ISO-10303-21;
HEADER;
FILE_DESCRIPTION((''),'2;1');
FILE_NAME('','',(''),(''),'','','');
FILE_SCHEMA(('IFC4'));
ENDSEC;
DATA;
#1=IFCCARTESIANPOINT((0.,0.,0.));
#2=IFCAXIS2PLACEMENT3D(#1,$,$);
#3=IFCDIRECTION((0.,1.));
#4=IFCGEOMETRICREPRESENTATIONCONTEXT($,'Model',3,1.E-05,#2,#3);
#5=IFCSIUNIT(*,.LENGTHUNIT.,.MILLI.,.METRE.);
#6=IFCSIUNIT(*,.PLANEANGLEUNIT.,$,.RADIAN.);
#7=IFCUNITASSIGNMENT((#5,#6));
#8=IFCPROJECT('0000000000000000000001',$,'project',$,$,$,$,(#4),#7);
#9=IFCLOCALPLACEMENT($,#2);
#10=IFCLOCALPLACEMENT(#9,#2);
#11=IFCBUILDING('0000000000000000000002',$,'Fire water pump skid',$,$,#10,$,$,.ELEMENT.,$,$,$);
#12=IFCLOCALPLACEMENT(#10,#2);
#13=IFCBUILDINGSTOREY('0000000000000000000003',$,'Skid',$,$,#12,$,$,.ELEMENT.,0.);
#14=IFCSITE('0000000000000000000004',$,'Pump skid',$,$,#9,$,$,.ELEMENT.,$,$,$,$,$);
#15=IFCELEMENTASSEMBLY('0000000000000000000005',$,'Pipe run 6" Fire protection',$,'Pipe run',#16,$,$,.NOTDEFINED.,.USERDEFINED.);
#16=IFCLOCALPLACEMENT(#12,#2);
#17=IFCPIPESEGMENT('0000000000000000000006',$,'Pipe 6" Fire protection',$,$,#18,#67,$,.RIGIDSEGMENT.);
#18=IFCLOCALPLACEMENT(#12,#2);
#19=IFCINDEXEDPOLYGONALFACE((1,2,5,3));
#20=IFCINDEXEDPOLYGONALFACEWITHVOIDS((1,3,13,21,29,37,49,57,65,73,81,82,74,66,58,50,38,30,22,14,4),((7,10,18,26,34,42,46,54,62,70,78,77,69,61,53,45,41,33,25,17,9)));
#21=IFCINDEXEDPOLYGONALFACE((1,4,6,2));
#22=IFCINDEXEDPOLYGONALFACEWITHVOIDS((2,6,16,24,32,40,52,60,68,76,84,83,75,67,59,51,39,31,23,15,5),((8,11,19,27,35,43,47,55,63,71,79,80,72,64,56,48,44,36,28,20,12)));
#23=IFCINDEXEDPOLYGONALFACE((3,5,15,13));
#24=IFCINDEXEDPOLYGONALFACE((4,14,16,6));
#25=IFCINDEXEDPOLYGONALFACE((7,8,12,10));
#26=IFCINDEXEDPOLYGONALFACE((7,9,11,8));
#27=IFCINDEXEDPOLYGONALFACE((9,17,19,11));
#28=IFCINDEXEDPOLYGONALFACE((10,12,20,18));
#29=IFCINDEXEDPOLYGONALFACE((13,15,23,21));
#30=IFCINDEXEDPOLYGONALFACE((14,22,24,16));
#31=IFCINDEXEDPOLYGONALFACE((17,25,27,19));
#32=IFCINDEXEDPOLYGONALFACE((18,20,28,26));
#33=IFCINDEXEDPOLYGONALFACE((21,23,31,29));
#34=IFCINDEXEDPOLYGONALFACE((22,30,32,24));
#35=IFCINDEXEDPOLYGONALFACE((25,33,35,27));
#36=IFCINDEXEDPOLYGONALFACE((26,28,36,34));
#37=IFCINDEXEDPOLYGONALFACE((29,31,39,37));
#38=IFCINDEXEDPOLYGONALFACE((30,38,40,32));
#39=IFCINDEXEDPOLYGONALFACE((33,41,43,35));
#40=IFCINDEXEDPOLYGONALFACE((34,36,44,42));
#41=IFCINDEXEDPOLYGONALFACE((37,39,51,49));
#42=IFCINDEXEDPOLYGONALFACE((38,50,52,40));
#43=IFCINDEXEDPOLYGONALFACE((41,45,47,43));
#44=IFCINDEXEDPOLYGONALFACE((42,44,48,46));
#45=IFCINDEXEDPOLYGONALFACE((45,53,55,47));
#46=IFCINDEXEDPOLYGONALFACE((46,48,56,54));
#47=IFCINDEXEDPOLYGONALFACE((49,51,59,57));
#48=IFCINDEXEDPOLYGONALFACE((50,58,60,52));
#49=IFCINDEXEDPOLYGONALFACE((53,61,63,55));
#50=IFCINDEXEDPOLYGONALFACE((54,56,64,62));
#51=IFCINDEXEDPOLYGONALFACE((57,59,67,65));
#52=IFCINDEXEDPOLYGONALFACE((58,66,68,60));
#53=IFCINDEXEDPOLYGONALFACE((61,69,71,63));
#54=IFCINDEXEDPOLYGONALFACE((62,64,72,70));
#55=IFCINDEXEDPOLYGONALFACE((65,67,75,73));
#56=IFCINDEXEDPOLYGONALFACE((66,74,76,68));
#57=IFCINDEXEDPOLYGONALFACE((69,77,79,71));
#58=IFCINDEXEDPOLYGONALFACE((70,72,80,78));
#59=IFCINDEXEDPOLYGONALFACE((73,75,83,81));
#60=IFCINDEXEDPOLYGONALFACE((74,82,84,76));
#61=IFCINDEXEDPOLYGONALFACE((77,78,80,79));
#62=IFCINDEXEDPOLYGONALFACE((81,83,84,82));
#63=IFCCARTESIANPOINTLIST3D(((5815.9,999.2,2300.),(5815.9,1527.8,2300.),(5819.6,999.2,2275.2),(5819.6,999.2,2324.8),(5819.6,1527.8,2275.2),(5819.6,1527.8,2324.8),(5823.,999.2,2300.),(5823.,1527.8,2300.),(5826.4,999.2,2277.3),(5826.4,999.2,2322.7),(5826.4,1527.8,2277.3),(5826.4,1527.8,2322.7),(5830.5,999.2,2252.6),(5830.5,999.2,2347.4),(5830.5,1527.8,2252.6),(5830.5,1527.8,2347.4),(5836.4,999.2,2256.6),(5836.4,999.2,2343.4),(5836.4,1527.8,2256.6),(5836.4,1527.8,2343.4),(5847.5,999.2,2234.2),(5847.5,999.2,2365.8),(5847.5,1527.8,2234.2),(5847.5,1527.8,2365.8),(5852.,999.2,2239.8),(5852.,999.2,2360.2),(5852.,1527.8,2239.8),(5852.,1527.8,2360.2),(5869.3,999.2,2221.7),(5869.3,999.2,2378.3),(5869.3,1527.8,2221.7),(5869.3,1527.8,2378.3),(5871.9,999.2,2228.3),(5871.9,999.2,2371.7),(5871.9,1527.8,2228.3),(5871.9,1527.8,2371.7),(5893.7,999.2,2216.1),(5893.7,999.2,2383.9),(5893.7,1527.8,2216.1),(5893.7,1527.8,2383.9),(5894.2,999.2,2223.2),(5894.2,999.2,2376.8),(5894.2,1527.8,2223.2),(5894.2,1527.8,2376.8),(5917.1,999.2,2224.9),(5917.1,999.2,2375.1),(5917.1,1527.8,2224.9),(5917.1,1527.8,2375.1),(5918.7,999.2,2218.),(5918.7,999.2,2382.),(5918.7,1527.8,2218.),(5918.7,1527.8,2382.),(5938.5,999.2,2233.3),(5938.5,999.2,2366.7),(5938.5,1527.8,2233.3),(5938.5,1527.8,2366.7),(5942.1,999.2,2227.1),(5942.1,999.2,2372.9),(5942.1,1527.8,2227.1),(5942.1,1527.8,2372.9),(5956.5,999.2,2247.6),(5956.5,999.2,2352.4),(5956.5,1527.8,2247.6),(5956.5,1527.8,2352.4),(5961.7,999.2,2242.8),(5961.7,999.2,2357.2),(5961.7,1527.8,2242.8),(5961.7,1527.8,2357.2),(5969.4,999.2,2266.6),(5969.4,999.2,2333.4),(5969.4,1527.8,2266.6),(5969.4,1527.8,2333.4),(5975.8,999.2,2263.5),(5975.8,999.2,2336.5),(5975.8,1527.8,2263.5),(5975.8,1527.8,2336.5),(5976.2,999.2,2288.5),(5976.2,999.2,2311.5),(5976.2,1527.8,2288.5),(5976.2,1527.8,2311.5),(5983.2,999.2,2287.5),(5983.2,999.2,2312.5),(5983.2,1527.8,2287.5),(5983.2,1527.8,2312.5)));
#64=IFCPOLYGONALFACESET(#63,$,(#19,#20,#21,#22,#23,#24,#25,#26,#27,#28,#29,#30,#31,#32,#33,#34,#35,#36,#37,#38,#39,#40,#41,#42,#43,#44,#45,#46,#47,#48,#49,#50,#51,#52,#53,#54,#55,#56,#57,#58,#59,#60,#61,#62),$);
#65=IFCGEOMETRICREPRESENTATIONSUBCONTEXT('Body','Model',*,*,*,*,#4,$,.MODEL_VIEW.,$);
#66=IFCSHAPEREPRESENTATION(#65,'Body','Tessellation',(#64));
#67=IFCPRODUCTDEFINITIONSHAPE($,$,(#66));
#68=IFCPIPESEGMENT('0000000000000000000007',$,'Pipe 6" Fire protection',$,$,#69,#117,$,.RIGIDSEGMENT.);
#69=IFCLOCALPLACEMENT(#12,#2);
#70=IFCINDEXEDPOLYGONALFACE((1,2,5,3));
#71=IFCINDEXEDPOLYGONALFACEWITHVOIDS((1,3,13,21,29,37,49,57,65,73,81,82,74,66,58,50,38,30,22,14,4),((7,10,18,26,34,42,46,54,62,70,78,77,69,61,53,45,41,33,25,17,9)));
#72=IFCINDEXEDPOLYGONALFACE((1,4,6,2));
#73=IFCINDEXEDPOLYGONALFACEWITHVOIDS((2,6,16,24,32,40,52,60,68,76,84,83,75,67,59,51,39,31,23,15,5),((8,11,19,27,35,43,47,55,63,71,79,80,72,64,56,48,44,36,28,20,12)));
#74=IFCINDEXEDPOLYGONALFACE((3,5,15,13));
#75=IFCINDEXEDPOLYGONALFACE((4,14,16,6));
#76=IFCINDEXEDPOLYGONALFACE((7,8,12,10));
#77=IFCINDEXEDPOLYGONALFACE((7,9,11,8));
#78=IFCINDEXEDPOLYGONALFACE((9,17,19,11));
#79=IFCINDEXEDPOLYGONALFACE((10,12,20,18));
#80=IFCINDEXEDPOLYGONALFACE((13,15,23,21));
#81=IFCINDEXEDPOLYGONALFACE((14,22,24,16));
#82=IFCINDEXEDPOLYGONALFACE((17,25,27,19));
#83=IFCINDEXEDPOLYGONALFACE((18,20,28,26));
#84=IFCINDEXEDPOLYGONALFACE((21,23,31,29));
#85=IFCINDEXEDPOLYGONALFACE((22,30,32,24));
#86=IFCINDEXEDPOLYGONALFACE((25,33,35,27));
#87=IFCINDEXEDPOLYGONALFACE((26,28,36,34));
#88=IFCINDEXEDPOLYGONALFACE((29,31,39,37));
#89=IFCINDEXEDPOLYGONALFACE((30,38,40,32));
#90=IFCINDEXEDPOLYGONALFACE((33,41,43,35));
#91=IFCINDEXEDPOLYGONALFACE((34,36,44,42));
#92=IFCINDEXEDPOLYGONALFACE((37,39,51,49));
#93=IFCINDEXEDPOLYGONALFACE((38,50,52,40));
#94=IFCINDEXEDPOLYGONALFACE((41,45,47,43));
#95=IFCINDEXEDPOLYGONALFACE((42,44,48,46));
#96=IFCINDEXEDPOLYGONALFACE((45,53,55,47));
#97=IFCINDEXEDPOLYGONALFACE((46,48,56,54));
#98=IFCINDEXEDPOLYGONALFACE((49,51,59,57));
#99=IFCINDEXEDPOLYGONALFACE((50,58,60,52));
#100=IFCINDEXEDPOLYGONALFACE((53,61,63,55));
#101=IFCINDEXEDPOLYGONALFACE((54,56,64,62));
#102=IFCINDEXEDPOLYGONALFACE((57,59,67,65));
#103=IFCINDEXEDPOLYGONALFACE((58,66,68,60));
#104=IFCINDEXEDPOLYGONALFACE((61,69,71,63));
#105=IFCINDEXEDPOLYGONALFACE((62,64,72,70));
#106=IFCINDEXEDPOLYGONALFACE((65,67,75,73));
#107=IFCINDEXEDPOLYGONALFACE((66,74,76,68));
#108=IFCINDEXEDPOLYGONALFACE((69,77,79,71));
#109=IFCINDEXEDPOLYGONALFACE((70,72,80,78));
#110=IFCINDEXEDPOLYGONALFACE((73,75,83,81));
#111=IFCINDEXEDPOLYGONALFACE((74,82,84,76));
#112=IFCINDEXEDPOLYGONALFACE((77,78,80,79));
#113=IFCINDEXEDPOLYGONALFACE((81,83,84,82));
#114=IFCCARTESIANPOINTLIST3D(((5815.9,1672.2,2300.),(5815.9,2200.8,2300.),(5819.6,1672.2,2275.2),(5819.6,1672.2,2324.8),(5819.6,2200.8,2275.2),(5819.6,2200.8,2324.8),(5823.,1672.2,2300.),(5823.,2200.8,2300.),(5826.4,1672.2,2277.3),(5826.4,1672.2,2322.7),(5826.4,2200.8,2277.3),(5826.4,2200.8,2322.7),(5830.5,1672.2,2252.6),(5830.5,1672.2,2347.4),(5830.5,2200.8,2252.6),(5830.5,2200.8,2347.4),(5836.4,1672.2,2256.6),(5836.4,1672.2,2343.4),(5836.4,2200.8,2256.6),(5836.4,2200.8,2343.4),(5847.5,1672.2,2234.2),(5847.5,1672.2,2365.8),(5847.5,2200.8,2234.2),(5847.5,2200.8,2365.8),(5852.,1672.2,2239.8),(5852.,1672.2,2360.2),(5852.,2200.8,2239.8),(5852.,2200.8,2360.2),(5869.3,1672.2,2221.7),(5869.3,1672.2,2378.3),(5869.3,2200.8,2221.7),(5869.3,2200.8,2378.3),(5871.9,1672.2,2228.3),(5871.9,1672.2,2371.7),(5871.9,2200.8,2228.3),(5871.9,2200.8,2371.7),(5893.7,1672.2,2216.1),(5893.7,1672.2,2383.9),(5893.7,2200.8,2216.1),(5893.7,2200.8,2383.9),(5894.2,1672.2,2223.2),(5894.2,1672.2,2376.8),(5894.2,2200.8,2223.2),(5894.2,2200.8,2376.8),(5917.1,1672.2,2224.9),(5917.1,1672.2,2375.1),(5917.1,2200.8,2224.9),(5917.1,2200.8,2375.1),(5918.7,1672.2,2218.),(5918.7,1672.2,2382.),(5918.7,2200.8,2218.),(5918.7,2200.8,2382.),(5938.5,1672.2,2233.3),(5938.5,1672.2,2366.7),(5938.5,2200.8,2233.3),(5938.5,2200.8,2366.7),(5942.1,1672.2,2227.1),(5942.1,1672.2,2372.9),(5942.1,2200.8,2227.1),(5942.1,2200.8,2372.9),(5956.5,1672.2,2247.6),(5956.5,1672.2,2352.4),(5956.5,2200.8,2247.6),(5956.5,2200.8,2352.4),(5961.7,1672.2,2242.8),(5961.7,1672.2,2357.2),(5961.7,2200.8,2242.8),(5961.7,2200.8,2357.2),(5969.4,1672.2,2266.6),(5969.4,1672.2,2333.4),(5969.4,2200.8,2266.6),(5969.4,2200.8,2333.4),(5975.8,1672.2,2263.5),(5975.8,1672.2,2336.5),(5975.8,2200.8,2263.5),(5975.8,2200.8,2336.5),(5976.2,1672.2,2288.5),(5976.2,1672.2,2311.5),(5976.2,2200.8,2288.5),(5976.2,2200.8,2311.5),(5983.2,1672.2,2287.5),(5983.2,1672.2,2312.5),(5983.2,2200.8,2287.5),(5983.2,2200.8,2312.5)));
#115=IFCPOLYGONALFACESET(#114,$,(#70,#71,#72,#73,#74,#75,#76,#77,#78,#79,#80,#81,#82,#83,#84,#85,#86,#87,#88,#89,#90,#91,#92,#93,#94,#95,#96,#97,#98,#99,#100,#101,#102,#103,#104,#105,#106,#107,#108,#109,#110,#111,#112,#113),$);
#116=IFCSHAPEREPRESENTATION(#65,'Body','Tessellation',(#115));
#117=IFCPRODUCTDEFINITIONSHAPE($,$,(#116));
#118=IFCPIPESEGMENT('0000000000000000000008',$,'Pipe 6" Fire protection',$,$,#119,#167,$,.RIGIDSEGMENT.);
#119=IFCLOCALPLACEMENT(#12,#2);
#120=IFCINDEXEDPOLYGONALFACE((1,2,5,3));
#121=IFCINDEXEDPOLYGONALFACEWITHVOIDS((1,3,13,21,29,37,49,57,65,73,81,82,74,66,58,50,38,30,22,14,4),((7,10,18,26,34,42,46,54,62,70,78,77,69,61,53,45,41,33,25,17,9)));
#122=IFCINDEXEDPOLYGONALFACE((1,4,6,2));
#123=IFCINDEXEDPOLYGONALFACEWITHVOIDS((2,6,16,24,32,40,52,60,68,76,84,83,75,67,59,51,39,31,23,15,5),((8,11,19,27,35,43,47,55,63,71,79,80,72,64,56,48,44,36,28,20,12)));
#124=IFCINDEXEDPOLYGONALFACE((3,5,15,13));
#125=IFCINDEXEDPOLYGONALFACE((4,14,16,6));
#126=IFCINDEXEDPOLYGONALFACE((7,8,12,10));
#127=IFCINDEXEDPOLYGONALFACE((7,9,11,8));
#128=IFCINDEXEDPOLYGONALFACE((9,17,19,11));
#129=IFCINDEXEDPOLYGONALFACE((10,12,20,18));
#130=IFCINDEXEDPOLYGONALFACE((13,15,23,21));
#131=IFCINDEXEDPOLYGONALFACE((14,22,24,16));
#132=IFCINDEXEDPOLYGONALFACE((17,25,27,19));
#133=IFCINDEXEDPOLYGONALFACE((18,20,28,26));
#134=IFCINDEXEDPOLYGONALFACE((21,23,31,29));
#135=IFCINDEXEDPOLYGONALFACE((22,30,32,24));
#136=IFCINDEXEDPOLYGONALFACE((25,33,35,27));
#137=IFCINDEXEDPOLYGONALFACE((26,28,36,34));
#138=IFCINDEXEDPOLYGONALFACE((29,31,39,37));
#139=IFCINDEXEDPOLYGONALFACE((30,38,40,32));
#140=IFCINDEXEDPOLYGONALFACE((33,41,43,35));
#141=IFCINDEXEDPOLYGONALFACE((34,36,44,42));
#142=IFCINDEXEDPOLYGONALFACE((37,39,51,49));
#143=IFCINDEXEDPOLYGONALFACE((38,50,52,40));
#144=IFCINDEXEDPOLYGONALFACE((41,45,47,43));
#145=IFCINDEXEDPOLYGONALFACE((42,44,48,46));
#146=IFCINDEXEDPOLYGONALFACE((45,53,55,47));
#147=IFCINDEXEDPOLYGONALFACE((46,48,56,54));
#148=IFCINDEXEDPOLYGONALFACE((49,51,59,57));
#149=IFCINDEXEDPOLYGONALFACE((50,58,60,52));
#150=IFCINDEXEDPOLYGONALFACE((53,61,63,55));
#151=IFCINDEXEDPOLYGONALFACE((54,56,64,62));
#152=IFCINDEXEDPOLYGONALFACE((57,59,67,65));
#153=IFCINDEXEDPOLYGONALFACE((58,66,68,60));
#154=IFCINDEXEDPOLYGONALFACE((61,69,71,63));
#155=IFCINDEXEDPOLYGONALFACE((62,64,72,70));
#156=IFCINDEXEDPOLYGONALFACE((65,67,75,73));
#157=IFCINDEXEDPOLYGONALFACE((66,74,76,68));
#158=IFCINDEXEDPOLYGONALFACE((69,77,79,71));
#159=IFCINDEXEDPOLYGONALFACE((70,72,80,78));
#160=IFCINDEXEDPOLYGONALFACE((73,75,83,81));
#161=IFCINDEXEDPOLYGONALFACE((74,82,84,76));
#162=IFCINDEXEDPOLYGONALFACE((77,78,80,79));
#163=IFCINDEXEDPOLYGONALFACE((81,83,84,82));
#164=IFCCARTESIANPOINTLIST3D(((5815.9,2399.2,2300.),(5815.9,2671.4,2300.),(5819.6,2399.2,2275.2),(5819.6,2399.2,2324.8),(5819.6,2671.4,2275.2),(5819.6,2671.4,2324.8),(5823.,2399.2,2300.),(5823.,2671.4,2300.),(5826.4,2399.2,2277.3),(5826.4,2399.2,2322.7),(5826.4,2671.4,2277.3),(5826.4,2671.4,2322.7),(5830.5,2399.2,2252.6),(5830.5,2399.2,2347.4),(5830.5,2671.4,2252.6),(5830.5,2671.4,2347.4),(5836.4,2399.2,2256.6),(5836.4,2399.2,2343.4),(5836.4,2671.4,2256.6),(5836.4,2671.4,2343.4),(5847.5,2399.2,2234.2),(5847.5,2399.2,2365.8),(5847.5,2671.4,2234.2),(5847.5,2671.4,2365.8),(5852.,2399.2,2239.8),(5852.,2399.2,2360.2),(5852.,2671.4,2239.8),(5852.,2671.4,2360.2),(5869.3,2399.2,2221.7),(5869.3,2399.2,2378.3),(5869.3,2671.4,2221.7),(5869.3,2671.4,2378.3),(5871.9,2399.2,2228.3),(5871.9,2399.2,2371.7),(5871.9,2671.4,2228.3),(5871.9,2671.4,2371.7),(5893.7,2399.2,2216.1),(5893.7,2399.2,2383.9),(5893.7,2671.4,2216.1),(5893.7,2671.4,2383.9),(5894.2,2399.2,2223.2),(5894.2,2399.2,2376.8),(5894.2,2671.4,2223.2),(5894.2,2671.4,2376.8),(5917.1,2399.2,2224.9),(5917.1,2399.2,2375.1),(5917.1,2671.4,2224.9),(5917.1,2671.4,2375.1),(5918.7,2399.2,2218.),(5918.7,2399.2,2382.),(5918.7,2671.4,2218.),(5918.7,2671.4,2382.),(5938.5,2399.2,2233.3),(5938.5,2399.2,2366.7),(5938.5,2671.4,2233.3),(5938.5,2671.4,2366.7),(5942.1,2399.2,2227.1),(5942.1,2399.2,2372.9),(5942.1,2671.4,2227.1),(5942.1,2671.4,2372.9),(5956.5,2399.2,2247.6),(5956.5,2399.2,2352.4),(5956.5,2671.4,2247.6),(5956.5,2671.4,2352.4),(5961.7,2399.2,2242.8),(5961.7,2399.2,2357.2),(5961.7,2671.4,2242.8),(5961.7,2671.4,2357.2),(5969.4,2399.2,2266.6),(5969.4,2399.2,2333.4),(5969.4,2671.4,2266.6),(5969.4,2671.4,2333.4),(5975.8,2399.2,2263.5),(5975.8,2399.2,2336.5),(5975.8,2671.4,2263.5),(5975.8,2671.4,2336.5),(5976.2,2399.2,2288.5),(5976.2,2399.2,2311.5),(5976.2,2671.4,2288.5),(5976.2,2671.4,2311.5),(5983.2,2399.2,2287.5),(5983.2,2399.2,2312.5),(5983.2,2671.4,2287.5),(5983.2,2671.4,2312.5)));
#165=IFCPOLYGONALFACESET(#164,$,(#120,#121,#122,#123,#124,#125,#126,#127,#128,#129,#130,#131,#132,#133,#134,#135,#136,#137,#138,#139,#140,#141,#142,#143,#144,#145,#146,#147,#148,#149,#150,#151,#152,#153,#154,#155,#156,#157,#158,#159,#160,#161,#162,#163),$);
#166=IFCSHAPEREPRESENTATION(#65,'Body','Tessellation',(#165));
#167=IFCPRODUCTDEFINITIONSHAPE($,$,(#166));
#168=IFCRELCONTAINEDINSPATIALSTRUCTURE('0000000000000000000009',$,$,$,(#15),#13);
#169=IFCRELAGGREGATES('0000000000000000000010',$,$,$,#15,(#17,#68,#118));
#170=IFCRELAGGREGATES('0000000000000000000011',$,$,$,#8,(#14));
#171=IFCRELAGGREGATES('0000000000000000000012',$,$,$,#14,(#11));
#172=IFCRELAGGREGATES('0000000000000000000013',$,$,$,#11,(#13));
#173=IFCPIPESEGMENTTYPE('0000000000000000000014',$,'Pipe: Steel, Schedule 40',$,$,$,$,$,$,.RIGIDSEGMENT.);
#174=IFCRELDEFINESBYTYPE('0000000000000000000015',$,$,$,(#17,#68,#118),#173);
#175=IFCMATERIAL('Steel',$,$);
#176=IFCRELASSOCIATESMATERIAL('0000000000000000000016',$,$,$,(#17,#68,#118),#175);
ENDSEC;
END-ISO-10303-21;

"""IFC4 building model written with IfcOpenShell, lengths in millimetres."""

from ifc_helpers import new_model, si_unit, direction, frame, origin, origin_with_axes, origin_2d, place, context, subcontext, project, spatial, hollow_circle, extrude, material, type_object, element, aggregate, save


model = new_model("IFC4")

# Units and contexts
model_context = context("Model", 3, precision=1e-05, world=origin(), true_north=direction((0.0, 1.0)))
body_context = subcontext(model_context, "Body", "Model", "MODEL_VIEW")
ifc_project = project(units=[si_unit("LENGTHUNIT", "METRE", prefix="MILLI"), si_unit("PLANEANGLEUNIT", "RADIAN")], contexts=[model_context])

# Site, building, storey
site_placement = place(None, origin())
site = spatial("IfcSite", under=ifc_project, at=site_placement, Name="Pump skid", CompositionType="ELEMENT")
building_placement = place(site_placement, origin())
building = spatial("IfcBuilding", under=site, at=building_placement, Name="Fire water pump skid", CompositionType="ELEMENT")
storey_placement = place(building_placement, origin())
storey = spatial("IfcBuildingStorey", under=building, at=storey_placement, Name="Skid", CompositionType="ELEMENT", Elevation=0.0)

# Element assembly, pipe segments
ifc_material = material(Name="Steel")
pipe_segment_type = type_object("IfcPipeSegmentType", Name="Pipe: Steel, Schedule 40", PredefinedType="RIGIDSEGMENT")
assembly_1_placement = place(storey_placement, origin_with_axes())
assembly_1 = element("IfcElementAssembly", 1, at=assembly_1_placement, inside=storey, Name="Pipe run 6\" Fire protection", ObjectType="Pipe run", AssemblyPlace="NOTDEFINED", PredefinedType="USERDEFINED")
pipe_segment_1_placement = place(storey_placement, origin_with_axes())
pipe_segment_1 = element("IfcPipeSegment", 2, at=pipe_segment_1_placement, type_object=pipe_segment_type, material=ifc_material, Name="Pipe 6\" Fire protection", PredefinedType="RIGIDSEGMENT", context=body_context, shape_type="SweptSolid", body=[
    extrude(hollow_circle(Radius=84.1, WallThickness=7.1, at=origin_2d()), frame((5900.0, 999.2, 2300.0), z_axis=(0.0, 1.0, 0.0), x_axis=(-1.0, 0.0, 0.0)), (0.0, 0.0, 1.0), 528.5),
])
pipe_segment_2_placement = place(storey_placement, origin_with_axes())
pipe_segment_2 = element("IfcPipeSegment", 3, at=pipe_segment_2_placement, type_object=pipe_segment_type, material=ifc_material, Name="Pipe 6\" Fire protection", PredefinedType="RIGIDSEGMENT", context=body_context, shape_type="SweptSolid", body=[
    extrude(hollow_circle(Radius=84.1, WallThickness=7.1, at=origin_2d()), frame((5900.0, 1672.2, 2300.0), z_axis=(0.0, 1.0, 0.0), x_axis=(-1.0, 0.0, 0.0)), (0.0, 0.0, 1.0), 528.5),
])
pipe_segment_3_placement = place(storey_placement, origin_with_axes())
pipe_segment_3 = element("IfcPipeSegment", 4, at=pipe_segment_3_placement, type_object=pipe_segment_type, material=ifc_material, Name="Pipe 6\" Fire protection", PredefinedType="RIGIDSEGMENT", context=body_context, shape_type="SweptSolid", body=[
    extrude(hollow_circle(Radius=84.1, WallThickness=7.1, at=origin_2d()), frame((5900.0, 2399.2, 2300.0), z_axis=(0.0, 1.0, 0.0), x_axis=(-1.0, 0.0, 0.0)), (0.0, 0.0, 1.0), 272.2),
])

aggregate(assembly_1, [pipe_segment_1, pipe_segment_2, pipe_segment_3])

save(model, "model.ifc")
